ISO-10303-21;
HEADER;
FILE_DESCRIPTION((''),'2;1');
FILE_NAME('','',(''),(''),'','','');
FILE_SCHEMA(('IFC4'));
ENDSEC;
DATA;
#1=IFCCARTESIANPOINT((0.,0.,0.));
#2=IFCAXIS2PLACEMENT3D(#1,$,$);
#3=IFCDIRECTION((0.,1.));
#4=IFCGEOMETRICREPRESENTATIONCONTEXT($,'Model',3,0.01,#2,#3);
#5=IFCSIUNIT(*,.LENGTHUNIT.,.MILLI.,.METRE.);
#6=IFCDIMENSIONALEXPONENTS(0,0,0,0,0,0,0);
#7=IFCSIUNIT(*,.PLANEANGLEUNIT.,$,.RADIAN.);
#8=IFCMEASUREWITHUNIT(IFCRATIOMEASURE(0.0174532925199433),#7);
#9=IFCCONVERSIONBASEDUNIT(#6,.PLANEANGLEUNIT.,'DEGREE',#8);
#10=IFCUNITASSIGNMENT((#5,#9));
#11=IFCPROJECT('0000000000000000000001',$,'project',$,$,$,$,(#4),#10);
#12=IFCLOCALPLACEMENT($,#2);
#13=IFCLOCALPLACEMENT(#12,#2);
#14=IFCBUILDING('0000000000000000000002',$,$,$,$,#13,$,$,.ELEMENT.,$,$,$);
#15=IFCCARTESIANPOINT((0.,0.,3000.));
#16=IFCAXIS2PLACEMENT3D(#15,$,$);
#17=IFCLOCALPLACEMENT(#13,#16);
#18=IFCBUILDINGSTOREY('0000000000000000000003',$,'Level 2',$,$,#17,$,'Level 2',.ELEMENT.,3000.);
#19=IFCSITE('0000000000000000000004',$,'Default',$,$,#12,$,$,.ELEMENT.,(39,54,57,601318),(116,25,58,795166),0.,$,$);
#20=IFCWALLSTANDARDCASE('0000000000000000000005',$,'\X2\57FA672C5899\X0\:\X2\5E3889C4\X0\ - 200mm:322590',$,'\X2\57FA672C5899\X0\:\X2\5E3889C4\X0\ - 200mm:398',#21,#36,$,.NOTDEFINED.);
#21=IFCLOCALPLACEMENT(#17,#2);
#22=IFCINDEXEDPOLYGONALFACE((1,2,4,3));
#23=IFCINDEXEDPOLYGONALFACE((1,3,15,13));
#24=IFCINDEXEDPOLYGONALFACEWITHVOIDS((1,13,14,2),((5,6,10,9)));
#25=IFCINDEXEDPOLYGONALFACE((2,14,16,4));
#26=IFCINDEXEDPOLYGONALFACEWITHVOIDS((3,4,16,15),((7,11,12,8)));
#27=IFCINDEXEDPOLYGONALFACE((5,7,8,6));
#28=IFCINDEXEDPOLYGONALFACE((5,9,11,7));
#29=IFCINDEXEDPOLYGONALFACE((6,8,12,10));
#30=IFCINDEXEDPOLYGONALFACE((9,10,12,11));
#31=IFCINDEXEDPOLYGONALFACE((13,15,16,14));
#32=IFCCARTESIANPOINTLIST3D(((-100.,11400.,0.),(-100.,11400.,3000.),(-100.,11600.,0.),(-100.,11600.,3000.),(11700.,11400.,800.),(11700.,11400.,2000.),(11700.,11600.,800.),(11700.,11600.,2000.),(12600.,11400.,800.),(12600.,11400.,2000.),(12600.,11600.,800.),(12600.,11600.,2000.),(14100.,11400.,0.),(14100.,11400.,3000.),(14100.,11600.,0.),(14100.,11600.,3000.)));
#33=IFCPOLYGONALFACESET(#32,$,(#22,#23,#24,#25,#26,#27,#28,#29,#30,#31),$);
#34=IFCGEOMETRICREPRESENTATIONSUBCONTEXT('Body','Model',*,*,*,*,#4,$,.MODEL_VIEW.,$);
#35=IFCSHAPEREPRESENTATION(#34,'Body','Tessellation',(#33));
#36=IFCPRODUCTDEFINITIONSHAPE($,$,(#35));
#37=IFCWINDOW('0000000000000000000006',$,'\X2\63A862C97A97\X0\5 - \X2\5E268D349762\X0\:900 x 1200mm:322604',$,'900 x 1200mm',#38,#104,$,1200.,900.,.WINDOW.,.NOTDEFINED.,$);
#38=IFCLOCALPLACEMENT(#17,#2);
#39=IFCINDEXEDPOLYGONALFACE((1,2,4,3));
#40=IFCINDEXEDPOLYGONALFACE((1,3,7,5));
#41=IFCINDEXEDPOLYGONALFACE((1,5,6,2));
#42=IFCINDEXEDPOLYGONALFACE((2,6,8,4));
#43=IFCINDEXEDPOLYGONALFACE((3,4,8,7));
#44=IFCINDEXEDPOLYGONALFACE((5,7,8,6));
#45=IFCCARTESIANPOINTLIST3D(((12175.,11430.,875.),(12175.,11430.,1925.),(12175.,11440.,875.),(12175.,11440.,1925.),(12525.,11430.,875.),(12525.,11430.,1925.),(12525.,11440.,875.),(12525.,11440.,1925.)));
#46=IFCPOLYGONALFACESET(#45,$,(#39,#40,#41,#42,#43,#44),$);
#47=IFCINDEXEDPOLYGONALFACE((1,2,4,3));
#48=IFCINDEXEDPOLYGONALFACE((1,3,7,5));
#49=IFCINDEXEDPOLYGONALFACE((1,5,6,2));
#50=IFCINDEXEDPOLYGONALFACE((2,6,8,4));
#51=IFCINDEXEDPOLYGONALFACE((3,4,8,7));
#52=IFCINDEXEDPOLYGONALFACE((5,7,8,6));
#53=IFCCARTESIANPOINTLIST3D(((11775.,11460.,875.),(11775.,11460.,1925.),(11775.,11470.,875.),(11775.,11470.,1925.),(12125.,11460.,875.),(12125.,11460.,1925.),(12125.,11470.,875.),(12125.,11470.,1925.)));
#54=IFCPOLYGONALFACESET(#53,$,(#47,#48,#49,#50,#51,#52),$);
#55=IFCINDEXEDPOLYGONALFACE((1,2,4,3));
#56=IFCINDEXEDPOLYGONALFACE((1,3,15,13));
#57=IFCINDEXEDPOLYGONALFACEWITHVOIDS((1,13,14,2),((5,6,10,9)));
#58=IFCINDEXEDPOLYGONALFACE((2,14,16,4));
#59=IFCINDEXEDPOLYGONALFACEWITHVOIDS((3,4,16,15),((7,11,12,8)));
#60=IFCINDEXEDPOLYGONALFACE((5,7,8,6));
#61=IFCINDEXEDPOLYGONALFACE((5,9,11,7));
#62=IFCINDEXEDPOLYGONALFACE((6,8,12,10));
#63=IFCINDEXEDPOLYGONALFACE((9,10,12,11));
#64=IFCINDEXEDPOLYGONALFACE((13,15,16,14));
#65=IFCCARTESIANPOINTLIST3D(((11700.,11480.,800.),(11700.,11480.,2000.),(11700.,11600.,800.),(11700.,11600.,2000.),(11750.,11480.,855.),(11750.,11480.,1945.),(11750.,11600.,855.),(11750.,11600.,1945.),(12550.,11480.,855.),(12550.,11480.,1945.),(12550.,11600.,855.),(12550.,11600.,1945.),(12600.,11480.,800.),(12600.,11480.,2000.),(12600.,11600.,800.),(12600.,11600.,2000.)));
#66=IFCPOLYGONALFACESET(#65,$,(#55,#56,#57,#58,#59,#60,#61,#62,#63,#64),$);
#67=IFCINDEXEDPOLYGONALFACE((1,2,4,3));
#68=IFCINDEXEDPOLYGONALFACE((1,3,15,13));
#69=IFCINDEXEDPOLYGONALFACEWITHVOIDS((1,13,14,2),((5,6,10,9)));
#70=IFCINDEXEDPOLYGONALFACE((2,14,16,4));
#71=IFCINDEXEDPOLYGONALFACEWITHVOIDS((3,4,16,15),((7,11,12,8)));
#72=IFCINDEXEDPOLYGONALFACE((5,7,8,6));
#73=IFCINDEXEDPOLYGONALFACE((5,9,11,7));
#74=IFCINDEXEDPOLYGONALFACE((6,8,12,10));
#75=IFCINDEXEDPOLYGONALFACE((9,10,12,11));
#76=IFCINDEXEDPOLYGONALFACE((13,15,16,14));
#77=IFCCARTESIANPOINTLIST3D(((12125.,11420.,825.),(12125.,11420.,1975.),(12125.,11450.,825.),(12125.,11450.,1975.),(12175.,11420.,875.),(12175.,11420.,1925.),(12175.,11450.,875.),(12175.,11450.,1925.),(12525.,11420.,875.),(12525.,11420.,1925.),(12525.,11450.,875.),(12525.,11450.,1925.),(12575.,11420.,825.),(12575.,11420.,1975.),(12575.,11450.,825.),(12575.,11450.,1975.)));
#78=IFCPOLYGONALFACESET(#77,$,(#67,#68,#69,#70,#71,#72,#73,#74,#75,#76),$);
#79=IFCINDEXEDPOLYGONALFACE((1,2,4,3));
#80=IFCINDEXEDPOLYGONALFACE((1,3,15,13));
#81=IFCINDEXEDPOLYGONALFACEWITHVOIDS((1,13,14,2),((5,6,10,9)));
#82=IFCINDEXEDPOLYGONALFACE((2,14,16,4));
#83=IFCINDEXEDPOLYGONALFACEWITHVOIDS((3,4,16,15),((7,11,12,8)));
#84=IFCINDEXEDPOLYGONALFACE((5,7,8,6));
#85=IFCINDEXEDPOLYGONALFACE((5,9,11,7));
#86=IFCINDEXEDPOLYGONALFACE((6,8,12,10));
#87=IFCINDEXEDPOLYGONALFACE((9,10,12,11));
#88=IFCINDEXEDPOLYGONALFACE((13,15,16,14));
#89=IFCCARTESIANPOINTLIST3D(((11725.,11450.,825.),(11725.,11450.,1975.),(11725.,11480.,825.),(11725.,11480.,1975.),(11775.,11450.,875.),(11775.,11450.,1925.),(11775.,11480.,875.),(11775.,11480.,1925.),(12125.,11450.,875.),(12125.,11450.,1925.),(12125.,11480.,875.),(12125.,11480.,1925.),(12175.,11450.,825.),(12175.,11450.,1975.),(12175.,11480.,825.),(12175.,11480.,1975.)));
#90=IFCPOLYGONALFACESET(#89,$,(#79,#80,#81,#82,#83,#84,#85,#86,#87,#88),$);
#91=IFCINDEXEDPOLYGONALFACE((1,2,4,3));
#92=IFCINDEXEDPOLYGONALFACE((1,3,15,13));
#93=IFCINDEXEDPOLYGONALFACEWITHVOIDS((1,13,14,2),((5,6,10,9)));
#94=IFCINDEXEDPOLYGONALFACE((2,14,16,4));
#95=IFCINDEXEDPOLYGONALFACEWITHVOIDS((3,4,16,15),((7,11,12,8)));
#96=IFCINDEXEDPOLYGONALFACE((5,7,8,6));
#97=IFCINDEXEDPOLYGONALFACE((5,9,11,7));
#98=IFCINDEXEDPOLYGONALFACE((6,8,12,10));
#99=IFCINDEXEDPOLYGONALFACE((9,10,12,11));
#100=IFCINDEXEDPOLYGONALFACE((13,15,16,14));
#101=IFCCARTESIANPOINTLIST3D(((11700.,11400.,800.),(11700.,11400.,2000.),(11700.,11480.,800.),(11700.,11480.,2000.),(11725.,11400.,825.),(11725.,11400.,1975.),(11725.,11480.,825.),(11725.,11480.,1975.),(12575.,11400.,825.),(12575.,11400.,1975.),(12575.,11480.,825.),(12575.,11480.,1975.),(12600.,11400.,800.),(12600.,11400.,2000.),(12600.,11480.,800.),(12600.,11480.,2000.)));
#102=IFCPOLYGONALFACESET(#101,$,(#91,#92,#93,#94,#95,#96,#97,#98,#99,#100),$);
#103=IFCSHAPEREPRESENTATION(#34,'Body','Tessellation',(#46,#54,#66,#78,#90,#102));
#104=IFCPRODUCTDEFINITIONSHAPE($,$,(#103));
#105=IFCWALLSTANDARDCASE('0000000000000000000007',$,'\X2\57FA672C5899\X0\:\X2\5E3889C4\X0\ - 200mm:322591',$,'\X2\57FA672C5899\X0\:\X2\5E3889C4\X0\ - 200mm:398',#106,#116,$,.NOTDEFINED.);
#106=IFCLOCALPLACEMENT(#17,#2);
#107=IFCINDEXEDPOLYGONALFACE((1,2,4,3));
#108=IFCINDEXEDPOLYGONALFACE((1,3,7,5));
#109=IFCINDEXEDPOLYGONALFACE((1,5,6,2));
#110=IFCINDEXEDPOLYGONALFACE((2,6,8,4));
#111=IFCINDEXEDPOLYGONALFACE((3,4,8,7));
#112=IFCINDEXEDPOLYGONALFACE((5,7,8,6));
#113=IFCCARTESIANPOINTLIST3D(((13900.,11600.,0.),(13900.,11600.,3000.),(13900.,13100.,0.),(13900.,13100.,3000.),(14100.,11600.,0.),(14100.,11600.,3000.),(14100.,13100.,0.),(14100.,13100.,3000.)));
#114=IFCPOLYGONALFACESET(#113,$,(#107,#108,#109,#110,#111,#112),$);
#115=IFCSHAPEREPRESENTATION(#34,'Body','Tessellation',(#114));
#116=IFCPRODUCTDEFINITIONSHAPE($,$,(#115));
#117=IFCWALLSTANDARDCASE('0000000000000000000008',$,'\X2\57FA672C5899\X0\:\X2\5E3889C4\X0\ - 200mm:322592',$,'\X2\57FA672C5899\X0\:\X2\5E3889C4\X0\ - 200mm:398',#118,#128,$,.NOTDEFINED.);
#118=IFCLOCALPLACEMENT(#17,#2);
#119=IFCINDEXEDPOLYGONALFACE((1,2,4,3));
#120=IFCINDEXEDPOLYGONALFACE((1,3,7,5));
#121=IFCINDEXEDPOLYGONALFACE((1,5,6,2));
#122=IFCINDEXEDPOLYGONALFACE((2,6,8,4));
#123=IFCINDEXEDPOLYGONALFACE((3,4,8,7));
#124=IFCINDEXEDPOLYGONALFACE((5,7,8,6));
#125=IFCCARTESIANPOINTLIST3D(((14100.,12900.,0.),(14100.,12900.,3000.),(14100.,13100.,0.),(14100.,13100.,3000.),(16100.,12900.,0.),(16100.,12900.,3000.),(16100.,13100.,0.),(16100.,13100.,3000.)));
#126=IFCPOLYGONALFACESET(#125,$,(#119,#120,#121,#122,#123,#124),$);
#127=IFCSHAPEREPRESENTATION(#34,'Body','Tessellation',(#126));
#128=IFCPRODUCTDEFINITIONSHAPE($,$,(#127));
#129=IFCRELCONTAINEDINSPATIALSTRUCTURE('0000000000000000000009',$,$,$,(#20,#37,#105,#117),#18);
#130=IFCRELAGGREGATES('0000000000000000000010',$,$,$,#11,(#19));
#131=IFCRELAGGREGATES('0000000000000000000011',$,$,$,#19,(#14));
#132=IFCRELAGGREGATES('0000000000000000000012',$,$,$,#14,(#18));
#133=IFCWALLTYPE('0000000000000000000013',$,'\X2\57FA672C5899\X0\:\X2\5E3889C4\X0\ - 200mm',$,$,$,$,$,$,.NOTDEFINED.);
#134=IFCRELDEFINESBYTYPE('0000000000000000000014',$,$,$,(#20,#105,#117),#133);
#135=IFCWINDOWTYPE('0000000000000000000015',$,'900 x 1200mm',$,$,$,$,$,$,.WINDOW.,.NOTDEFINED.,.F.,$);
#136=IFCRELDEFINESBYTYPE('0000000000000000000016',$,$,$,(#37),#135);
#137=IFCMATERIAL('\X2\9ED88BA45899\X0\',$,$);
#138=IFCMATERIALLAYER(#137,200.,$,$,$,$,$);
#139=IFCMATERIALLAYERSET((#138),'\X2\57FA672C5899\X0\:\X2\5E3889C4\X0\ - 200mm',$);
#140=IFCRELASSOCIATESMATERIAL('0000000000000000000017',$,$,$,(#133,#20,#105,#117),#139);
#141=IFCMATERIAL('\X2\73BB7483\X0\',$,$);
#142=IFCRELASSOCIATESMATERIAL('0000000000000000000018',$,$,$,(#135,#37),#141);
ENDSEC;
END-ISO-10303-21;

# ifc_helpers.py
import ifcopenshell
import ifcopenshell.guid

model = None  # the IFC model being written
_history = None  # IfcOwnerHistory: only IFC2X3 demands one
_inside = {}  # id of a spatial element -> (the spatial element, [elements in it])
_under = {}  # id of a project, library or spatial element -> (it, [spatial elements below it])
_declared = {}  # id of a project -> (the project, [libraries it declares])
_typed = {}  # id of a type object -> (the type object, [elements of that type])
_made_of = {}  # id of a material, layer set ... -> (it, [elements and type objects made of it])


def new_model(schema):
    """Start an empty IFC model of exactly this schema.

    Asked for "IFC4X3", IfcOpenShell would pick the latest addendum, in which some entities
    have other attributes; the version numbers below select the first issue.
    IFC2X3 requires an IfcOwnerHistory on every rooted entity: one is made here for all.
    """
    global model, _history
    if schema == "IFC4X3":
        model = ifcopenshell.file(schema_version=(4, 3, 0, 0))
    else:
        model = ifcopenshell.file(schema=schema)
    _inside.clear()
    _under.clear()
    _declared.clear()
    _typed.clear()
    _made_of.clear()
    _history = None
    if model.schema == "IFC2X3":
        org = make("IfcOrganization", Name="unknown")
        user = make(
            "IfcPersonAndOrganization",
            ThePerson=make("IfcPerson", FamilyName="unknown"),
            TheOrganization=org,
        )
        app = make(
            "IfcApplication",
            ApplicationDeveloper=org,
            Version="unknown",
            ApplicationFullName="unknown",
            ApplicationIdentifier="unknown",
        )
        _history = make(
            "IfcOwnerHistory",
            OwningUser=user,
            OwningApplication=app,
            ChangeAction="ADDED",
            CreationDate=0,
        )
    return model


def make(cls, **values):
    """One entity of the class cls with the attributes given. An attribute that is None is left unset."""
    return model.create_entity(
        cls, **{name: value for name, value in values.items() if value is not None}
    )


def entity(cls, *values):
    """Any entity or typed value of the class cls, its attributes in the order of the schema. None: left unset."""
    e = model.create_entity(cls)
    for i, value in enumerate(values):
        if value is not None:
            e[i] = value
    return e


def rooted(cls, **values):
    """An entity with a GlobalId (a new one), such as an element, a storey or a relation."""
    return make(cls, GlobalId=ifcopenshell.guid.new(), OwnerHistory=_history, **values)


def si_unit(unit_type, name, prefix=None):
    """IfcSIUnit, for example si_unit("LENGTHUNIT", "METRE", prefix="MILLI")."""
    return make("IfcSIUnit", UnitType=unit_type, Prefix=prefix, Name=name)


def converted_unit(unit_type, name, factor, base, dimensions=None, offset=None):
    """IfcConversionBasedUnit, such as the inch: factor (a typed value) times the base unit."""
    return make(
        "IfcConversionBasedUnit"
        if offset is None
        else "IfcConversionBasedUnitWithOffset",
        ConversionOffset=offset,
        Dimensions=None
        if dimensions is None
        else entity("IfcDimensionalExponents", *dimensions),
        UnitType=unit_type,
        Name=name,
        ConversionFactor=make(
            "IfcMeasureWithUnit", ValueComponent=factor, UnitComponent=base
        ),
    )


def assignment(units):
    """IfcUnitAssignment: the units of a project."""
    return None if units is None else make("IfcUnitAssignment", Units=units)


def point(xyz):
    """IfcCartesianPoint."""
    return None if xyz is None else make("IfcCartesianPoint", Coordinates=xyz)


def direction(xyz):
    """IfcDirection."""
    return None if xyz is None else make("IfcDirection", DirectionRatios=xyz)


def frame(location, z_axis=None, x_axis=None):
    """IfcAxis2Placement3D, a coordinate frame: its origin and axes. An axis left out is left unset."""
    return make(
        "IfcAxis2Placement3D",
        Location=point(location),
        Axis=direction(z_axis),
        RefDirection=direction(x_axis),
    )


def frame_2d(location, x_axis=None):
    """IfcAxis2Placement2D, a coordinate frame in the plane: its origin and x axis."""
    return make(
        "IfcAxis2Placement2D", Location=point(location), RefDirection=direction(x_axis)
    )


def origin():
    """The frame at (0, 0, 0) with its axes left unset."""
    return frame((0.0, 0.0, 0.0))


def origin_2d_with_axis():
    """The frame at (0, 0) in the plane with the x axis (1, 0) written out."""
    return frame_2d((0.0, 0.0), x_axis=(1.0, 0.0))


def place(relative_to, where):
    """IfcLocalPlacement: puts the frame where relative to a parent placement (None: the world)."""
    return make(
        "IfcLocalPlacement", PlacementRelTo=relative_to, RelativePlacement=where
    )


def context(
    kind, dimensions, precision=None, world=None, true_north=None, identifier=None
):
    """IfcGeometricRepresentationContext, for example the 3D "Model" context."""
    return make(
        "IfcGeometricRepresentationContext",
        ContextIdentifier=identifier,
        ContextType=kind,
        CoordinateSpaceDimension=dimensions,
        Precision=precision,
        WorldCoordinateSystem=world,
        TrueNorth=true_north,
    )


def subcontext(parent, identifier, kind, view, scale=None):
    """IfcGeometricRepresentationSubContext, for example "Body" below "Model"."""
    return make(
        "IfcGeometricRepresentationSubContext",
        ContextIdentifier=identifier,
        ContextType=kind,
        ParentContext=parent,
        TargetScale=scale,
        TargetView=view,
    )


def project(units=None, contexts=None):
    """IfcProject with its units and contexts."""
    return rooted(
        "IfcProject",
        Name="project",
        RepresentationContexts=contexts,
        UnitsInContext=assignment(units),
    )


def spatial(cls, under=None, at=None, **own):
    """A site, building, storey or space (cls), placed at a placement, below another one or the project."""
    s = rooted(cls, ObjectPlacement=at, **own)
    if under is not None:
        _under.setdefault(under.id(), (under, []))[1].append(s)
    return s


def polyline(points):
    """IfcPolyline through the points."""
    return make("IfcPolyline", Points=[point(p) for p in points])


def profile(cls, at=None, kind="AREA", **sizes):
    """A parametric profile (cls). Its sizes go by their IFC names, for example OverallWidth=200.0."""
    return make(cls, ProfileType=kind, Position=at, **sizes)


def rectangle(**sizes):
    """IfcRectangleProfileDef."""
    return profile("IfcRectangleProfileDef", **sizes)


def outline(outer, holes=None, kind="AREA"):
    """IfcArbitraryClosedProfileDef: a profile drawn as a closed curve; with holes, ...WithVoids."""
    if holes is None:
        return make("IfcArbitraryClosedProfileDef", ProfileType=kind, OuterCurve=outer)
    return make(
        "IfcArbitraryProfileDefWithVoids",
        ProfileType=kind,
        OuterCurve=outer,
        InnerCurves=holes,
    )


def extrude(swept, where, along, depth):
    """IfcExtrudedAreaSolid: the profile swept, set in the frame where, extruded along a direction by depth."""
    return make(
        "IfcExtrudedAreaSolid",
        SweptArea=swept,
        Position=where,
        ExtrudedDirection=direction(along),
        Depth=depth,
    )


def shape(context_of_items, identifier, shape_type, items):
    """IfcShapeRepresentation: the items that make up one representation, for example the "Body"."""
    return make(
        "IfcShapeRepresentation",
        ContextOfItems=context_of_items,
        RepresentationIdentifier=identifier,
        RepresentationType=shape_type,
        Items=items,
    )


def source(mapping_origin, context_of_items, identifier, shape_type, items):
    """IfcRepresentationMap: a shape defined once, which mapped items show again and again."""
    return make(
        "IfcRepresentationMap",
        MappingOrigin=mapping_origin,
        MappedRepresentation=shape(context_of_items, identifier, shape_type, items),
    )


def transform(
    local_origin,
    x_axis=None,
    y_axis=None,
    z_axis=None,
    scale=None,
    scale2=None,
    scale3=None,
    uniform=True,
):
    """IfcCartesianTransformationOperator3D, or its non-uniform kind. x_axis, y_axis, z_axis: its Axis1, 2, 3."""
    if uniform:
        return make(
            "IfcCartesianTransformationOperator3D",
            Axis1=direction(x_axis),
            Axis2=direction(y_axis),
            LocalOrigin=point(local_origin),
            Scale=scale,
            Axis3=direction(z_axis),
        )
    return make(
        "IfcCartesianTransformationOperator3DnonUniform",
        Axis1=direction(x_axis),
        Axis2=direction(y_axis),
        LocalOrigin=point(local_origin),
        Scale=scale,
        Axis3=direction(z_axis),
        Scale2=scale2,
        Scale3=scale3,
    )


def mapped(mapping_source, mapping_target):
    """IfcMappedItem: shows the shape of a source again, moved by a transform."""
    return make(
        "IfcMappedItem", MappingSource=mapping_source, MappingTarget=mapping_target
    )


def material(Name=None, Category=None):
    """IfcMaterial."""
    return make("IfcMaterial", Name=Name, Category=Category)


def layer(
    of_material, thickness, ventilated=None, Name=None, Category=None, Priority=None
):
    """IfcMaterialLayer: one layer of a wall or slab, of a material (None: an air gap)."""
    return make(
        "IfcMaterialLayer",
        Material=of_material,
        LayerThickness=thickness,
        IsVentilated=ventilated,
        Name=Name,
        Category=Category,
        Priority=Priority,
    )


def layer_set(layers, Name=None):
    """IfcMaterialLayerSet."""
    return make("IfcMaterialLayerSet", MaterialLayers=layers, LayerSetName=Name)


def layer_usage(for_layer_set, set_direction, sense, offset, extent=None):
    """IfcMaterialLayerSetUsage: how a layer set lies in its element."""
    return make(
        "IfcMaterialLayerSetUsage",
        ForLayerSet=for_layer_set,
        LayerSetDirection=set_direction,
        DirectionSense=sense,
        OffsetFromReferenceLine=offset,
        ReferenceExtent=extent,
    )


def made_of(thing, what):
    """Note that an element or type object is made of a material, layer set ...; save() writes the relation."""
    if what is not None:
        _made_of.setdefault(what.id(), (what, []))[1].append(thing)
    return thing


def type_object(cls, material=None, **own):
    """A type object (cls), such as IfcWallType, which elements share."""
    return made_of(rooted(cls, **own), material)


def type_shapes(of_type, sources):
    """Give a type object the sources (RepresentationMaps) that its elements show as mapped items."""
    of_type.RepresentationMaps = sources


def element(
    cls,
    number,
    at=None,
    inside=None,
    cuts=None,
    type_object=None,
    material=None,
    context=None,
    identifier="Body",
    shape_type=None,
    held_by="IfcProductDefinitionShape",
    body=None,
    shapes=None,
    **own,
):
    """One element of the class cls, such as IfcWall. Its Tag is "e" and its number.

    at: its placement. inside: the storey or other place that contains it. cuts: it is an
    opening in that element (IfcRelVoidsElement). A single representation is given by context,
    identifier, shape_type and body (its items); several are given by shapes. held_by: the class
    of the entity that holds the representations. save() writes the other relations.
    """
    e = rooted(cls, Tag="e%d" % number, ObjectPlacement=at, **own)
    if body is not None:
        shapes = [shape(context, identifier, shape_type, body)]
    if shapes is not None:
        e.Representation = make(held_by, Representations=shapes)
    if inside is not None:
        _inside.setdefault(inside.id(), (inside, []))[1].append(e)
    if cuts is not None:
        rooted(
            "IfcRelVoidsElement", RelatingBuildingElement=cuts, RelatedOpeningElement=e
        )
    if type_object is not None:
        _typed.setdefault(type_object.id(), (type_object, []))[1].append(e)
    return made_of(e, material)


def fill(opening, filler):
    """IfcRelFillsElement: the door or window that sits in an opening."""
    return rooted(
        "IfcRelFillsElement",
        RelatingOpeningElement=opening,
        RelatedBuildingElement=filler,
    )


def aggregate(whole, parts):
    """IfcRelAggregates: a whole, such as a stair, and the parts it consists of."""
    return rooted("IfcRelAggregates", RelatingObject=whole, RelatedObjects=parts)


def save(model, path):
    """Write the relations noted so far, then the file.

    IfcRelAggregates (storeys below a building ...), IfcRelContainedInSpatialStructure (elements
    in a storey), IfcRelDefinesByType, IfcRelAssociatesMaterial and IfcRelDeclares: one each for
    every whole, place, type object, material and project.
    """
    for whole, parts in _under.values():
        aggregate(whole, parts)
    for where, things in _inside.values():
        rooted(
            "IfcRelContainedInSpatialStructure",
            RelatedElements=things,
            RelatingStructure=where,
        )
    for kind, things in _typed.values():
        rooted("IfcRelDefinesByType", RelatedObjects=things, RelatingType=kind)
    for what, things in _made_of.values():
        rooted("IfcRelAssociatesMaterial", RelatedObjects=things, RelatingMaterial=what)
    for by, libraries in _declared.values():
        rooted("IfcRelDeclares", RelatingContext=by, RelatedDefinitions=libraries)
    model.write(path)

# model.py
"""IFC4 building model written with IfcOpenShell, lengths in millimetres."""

from ifc_helpers import new_model, entity, si_unit, converted_unit, direction, frame, frame_2d, origin, origin_2d_with_axis, place, context, subcontext, project, spatial, polyline, rectangle, outline, extrude, source, transform, mapped, material, layer, layer_set, layer_usage, type_object, type_shapes, element, fill, save


model = new_model("IFC4")

# Units and contexts
model_context = context("Model", 3, precision=0.01, world=origin(), true_north=direction((0.0, 1.0)))
body_context = subcontext(model_context, "Body", "Model", "MODEL_VIEW")
ifc_project = project(units=[si_unit("LENGTHUNIT", "METRE", prefix="MILLI"), converted_unit("PLANEANGLEUNIT", "DEGREE", entity("IfcRatioMeasure", 0.0174532925199433), si_unit("PLANEANGLEUNIT", "RADIAN"), dimensions=[0, 0, 0, 0, 0, 0, 0])], contexts=[model_context])

# Site, building, storey
site_placement = place(None, origin())
site = spatial("IfcSite", under=ifc_project, at=site_placement, Name="Default", CompositionType="ELEMENT", RefLatitude=(39, 54, 57, 601318), RefLongitude=(116, 25, 58, 795166), RefElevation=0.0)
building_placement = place(site_placement, origin())
building = spatial("IfcBuilding", under=site, at=building_placement, CompositionType="ELEMENT")
storey_placement = place(building_placement, frame((0.0, 0.0, 3000.0)))
storey = spatial("IfcBuildingStorey", under=building, at=storey_placement, Name="Level 2", LongName="Level 2", CompositionType="ELEMENT", Elevation=3000.0)

# Shared definitions
ifc_material_1 = material(Name="默认墙")
ifc_layer_1 = layer(ifc_material_1, 200.0)
ifc_layer_set_1 = layer_set([ifc_layer_1], Name="基本墙:常规 - 200mm")
wall_type = type_object("IfcWallType", Name="基本墙:常规 - 200mm", PredefinedType="NOTDEFINED", material=ifc_layer_set_1)

# Wall, opening, window
ifc_layer_usage_1 = layer_usage(ifc_layer_set_1, "AXIS2", "NEGATIVE", 100.0)
wall_1_placement = place(storey_placement, frame((-100.0, 11500.0, 0.0)))
wall_1 = element("IfcWallStandardCase", 1, at=wall_1_placement, inside=storey, type_object=wall_type, material=ifc_layer_usage_1, Name="基本墙:常规 - 200mm:322590", ObjectType="基本墙:常规 - 200mm:398", PredefinedType="NOTDEFINED", context=body_context, shape_type="SweptSolid", body=[
    extrude(rectangle(XDim=14200.0, YDim=200.0, at=frame_2d((7100.0, 0.0), x_axis=(-1.0, 0.0))), origin(), (0.0, 0.0, 1.0), 3000.0),
])
opening_1_placement = place(wall_1_placement, frame((12700.0, 100.0, 800.0)))
opening_1 = element("IfcOpeningElement", 2, at=opening_1_placement, cuts=wall_1, ObjectType="Opening", PredefinedType="OPENING", context=body_context, shape_type="SweptSolid", body=[
    extrude(rectangle(XDim=1200.0, YDim=900.0, at=frame_2d((600.0, 450.0), x_axis=(-1.0, 0.0))), frame((0.0, 0.0, 0.0), z_axis=(0.0, -1.0, 0.0), x_axis=(0.0, 0.0, 1.0)), (0.0, 0.0, 1.0), 200.0),
])
ifc_material_2 = material(Name="玻璃")
window_type_1 = type_object("IfcWindowType", Name="900 x 1200mm", ParameterTakesPrecedence=False, PartitioningType="NOTDEFINED", PredefinedType="WINDOW", material=ifc_material_2)
shared_shape_1 = source(origin(), body_context, "Body", "SweptSolid", [
    extrude(rectangle(XDim=10.0, YDim=350.0, at=origin_2d_with_axis()), frame((250.0, 165.0, 75.0), z_axis=(0.0, 0.0, 1.0), x_axis=(0.0, -1.0, 0.0)), (0.0, 0.0, 1.0), 1050.0),
    extrude(rectangle(XDim=10.0, YDim=350.0, at=origin_2d_with_axis()), frame((650.0, 135.0, 75.0), z_axis=(0.0, 0.0, 1.0), x_axis=(0.0, -1.0, 0.0)), (0.0, 0.0, 1.0), 1050.0),
    extrude(outline(polyline([(-450.0, -600.0), (450.0, -600.0), (450.0, 600.0), (-450.0, 600.0), (-450.0, -600.0)]), holes=[polyline([(400.0, -545.0), (-400.0, -545.0), (-400.0, 545.0), (400.0, 545.0), (400.0, -545.0)])]), frame((450.0, 0.0, 600.0), z_axis=(0.0, 1.0, 0.0), x_axis=(1.0, 0.0, 0.0)), (0.0, 0.0, 1.0), 120.0),
    extrude(outline(polyline([(-225.0, -575.0), (225.0, -575.0), (225.0, 575.0), (-225.0, 575.0), (-225.0, -575.0)]), holes=[polyline([(-175.0, -525.0), (-175.0, 525.0), (175.0, 525.0), (175.0, -525.0), (-175.0, -525.0)])]), frame((250.0, 150.0, 600.0), z_axis=(0.0, 1.0, 0.0), x_axis=(-1.0, 0.0, 0.0)), (0.0, 0.0, 1.0), 30.0),
    extrude(outline(polyline([(-225.0, -575.0), (225.0, -575.0), (225.0, 575.0), (-225.0, 575.0), (-225.0, -575.0)]), holes=[polyline([(-175.0, -525.0), (-175.0, 525.0), (175.0, 525.0), (175.0, -525.0), (-175.0, -525.0)])]), frame((650.0, 120.0, 600.0), z_axis=(0.0, 1.0, 0.0), x_axis=(1.0, 0.0, 0.0)), (0.0, 0.0, 1.0), 30.0),
    extrude(outline(polyline([(-450.0, -600.0), (450.0, -600.0), (450.0, 600.0), (-450.0, 600.0), (-450.0, -600.0)]), holes=[polyline([(-425.0, 575.0), (425.0, 575.0), (425.0, -575.0), (-425.0, -575.0), (-425.0, 575.0)])]), frame((450.0, 120.0, 600.0), z_axis=(0.0, 1.0, 0.0), x_axis=(1.0, 0.0, 0.0)), (0.0, 0.0, 1.0), 80.0),
])
type_shapes(window_type_1, [shared_shape_1])
window_1_placement = place(opening_1_placement, frame((0.0, 0.0, 0.0), z_axis=(0.0, 0.0, 1.0), x_axis=(-1.0, 0.0, 0.0)))
window_1 = element("IfcWindow", 3, at=window_1_placement, inside=storey, type_object=window_type_1, material=ifc_material_2, Name="推拉窗5 - 带贴面:900 x 1200mm:322604", ObjectType="900 x 1200mm", OverallHeight=1200.0, OverallWidth=900.0, PartitioningType="NOTDEFINED", PredefinedType="WINDOW", context=body_context, shape_type="MappedRepresentation", body=[
    mapped(shared_shape_1, transform((0.0, 0.0, 0.0), scale=1.0)),
])
fill(opening_1, window_1)

# Walls
ifc_layer_usage_2 = layer_usage(ifc_layer_set_1, "AXIS2", "NEGATIVE", 100.0)
wall_2_placement = place(storey_placement, frame((14000.0, 11600.0, 0.0), z_axis=(0.0, 0.0, 1.0), x_axis=(0.0, 1.0, 0.0)))
element("IfcWallStandardCase", 4, at=wall_2_placement, inside=storey, type_object=wall_type, material=ifc_layer_usage_2, Name="基本墙:常规 - 200mm:322591", ObjectType="基本墙:常规 - 200mm:398", PredefinedType="NOTDEFINED", context=body_context, shape_type="SweptSolid", body=[
    extrude(rectangle(XDim=1500.0, YDim=200.0, at=frame_2d((750.0, 0.0), x_axis=(-1.0, 0.0))), origin(), (0.0, 0.0, 1.0), 3000.0),
])
ifc_layer_usage_3 = layer_usage(ifc_layer_set_1, "AXIS2", "NEGATIVE", 100.0)
wall_3_placement = place(storey_placement, frame((14100.0, 13000.0, 0.0)))
element("IfcWallStandardCase", 5, at=wall_3_placement, inside=storey, type_object=wall_type, material=ifc_layer_usage_3, Name="基本墙:常规 - 200mm:322592", ObjectType="基本墙:常规 - 200mm:398", PredefinedType="NOTDEFINED", context=body_context, shape_type="SweptSolid", body=[
    extrude(rectangle(XDim=2000.0, YDim=200.0, at=frame_2d((1000.0, 0.0), x_axis=(-1.0, 0.0))), origin(), (0.0, 0.0, 1.0), 3000.0),
])

save(model, "model.ifc")
